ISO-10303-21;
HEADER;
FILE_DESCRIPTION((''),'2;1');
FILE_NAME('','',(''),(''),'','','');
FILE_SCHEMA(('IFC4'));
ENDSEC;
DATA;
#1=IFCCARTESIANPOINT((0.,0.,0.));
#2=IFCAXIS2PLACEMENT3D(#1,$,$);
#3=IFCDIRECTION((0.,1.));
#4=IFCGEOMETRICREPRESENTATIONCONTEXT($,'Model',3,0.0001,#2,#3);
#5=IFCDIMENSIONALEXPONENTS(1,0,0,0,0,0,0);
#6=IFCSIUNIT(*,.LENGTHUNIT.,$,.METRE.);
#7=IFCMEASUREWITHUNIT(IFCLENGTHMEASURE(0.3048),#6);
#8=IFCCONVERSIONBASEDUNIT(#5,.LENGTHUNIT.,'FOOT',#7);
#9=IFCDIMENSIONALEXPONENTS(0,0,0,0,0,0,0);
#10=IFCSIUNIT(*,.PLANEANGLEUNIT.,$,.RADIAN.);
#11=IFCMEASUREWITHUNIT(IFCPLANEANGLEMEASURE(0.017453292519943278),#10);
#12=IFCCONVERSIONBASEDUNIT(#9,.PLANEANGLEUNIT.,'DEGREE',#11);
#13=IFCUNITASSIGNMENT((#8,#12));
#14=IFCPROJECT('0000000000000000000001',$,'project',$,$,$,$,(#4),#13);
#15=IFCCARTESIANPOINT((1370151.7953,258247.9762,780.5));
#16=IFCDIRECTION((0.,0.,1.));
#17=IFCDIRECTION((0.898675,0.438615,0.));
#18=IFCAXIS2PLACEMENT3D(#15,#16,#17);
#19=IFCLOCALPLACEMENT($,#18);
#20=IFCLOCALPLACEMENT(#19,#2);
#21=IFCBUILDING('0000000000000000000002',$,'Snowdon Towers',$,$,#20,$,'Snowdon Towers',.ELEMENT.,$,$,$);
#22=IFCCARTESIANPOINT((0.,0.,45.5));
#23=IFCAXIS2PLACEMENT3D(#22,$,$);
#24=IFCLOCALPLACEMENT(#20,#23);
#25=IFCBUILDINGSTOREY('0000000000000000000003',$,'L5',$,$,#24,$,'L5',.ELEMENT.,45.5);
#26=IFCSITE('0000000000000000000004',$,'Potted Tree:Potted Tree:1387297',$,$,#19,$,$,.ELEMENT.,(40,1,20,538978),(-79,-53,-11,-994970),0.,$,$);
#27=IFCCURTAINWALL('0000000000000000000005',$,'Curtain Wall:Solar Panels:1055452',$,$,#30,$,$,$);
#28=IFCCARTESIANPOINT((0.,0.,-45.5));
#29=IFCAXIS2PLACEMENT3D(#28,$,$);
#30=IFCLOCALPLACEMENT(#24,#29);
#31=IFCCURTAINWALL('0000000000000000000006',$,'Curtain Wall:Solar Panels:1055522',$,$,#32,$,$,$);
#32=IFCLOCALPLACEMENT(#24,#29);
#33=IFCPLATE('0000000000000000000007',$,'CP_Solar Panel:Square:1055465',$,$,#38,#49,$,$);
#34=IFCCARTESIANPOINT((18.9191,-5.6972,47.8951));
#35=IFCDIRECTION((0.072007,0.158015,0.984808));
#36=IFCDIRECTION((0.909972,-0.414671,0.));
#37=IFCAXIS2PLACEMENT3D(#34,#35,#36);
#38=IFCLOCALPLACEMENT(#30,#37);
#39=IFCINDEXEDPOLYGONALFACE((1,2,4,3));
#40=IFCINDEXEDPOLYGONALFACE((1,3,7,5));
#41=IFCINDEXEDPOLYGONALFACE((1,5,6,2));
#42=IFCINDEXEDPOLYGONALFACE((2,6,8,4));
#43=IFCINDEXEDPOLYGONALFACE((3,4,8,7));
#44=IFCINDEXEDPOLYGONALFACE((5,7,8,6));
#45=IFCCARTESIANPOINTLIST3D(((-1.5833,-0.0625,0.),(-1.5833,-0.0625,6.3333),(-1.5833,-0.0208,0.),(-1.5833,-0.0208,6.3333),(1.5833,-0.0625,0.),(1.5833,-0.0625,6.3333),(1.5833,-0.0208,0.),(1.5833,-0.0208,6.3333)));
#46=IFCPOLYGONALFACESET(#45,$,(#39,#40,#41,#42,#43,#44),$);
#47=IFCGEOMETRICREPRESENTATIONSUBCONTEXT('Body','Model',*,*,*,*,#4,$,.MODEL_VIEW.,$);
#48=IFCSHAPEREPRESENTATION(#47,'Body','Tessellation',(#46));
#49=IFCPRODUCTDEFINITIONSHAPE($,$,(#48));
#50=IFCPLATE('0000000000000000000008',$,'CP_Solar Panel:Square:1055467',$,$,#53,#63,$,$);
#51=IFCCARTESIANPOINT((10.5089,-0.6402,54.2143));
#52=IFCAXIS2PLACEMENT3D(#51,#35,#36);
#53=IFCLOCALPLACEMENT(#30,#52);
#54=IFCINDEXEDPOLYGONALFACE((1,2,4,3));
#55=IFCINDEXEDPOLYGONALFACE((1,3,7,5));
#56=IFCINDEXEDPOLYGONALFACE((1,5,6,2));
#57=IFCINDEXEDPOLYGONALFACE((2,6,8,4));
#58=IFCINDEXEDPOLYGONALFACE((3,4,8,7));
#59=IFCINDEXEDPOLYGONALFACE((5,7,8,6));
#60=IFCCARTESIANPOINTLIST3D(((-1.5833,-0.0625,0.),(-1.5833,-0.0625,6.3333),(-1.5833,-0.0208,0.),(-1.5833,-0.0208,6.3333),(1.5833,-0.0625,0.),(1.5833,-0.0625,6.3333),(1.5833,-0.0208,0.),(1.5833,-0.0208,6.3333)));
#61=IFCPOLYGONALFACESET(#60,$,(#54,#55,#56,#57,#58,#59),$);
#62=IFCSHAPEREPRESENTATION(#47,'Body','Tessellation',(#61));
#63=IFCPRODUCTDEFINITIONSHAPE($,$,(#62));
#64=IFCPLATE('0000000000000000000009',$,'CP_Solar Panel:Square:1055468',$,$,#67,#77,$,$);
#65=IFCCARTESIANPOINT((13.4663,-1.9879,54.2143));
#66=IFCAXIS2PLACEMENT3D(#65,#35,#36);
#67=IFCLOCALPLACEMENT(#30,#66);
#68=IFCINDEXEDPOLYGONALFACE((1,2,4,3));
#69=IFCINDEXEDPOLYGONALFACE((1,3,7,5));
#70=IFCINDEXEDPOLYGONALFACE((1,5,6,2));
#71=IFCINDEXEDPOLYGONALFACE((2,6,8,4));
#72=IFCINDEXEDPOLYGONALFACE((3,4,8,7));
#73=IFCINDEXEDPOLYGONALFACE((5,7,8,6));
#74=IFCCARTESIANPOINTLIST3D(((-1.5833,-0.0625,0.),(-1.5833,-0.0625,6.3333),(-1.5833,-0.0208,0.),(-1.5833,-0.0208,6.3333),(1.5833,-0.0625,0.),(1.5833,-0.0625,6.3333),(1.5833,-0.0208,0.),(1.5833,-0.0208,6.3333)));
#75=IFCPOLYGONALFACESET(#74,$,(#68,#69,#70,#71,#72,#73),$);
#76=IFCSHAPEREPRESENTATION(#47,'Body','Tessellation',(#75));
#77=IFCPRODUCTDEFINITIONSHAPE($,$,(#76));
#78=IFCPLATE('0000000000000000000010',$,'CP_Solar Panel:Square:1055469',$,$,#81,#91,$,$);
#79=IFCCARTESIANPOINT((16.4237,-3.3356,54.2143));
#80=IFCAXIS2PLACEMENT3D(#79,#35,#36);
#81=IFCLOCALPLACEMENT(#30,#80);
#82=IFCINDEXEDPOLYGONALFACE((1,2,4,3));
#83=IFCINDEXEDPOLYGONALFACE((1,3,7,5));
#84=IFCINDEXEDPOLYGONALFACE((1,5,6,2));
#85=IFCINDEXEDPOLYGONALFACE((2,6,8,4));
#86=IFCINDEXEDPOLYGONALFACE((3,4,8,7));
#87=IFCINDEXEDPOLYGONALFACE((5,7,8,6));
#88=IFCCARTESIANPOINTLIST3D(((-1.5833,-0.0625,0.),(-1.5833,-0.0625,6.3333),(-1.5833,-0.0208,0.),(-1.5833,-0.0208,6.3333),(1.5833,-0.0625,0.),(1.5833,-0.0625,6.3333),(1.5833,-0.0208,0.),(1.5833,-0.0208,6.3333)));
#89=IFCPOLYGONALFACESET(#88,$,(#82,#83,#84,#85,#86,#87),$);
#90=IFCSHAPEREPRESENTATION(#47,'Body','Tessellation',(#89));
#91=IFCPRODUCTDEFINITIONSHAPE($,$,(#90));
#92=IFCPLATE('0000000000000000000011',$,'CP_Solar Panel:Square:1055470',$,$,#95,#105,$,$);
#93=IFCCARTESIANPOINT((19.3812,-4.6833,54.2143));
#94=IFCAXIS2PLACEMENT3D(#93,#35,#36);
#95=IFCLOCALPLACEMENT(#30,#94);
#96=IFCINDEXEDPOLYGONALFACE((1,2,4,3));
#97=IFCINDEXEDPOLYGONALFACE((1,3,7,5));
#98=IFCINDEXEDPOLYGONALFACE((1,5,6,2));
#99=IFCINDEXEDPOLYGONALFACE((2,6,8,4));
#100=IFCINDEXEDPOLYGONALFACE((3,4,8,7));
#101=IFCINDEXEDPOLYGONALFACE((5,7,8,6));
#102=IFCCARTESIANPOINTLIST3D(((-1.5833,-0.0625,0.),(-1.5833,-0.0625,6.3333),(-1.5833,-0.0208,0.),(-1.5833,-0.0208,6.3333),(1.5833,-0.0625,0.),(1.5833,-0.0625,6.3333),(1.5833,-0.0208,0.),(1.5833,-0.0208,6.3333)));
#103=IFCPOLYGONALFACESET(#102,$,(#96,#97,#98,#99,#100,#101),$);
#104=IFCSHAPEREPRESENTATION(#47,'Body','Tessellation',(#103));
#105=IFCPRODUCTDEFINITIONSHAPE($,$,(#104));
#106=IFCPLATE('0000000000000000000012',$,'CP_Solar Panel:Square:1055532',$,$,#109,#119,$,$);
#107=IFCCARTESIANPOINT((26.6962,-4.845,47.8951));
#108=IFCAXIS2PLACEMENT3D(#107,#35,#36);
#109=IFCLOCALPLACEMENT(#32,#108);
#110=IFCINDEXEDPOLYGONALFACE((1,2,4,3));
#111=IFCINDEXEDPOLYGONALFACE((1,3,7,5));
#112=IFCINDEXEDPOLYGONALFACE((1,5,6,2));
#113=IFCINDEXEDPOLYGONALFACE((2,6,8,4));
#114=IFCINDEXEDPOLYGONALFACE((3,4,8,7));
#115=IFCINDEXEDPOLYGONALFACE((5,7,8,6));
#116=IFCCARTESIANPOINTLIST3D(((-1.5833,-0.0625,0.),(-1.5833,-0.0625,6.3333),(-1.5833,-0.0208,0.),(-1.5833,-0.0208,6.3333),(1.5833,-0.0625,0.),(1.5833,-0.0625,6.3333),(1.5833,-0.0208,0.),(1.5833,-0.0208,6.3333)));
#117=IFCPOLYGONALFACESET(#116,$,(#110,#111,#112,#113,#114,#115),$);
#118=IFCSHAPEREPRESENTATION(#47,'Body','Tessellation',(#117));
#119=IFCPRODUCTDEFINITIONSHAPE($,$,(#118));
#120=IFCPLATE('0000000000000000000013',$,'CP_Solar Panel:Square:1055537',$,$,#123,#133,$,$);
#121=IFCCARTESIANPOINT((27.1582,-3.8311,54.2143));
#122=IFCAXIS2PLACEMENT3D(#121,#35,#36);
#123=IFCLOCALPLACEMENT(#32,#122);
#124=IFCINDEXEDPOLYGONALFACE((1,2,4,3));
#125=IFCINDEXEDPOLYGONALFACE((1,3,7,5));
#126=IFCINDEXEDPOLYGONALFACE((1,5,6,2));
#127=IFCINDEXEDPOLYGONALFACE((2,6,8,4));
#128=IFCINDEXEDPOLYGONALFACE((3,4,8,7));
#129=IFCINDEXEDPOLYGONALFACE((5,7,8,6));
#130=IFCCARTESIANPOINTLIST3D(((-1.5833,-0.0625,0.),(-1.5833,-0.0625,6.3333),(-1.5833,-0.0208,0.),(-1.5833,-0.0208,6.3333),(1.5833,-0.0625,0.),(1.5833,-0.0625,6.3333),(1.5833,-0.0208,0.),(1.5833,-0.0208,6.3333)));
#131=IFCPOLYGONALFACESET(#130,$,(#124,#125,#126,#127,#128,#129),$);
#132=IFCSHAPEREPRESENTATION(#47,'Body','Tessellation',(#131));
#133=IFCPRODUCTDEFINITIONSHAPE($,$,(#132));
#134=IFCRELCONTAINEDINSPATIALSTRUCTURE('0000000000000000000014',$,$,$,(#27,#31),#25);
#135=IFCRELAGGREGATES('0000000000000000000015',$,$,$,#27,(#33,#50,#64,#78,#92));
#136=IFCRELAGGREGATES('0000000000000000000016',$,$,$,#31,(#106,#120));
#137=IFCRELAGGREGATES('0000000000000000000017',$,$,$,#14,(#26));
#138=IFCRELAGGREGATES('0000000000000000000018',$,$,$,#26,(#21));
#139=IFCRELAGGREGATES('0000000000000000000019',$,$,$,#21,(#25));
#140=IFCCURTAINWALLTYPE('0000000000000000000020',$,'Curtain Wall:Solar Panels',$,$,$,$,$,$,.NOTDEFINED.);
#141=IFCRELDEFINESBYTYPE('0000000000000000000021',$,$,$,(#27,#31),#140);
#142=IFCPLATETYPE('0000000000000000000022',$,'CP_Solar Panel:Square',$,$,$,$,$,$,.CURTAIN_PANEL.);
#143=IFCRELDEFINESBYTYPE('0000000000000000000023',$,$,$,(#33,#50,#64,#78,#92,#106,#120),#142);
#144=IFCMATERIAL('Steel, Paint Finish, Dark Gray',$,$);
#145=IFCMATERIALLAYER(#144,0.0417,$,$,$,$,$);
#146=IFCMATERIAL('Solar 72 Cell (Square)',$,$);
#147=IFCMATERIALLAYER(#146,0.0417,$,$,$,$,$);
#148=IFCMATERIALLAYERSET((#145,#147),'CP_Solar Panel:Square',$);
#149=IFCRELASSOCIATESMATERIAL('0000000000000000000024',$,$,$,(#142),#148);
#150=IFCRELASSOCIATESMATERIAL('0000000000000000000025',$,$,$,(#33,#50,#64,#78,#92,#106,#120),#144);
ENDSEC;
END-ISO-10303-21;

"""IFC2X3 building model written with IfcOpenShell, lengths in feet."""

from ifc_helpers import new_model, entity, si_unit, converted_unit, direction, frame, origin, origin_2d_with_axis, place, context, subcontext, project, spatial, rectangle, extrude, source, transform, mapped, material, layer, layer_set, type_object, type_shapes, element, aggregate, save


model = new_model("IFC2X3")

# Units and contexts
model_context = context("Model", 3, precision=0.0001, world=origin(), true_north=direction((0.0, 1.0)))
body_context = subcontext(model_context, "Body", "Model", "MODEL_VIEW")
ifc_project = project(units=[converted_unit("LENGTHUNIT", "FOOT", entity("IfcLengthMeasure", 0.3048), si_unit("LENGTHUNIT", "METRE"), dimensions=[1, 0, 0, 0, 0, 0, 0]), converted_unit("PLANEANGLEUNIT", "DEGREE", entity("IfcPlaneAngleMeasure", 0.017453292519943278), si_unit("PLANEANGLEUNIT", "RADIAN"), dimensions=[0, 0, 0, 0, 0, 0, 0])], contexts=[model_context])

# Site, building, storey
site_placement = place(None, frame((1370151.7953, 258247.9762, 780.5), z_axis=(0.0, 0.0, 1.0), x_axis=(0.898675, 0.438615, 0.0)))
site = spatial("IfcSite", under=ifc_project, at=site_placement, Name="Potted Tree:Potted Tree:1387297", CompositionType="ELEMENT", RefLatitude=(40, 1, 20, 538978), RefLongitude=(-79, -53, -11, -994970), RefElevation=0.0)
building_placement = place(site_placement, origin())
building = spatial("IfcBuilding", under=site, at=building_placement, Name="Snowdon Towers", LongName="Snowdon Towers", CompositionType="ELEMENT")
storey_placement = place(building_placement, frame((0.0, 0.0, 45.5)))
storey = spatial("IfcBuildingStorey", under=building, at=storey_placement, Name="L5", LongName="L5", CompositionType="ELEMENT", Elevation=45.5)

# Curtain wall
curtain_wall_type = type_object("IfcCurtainWallType", Name="Curtain Wall:Solar Panels", PredefinedType="NOTDEFINED")
curtain_wall_1_placement = place(storey_placement, frame((0.0, 0.0, -45.5)))
curtain_wall_1 = element("IfcCurtainWall", 1, at=curtain_wall_1_placement, inside=storey, type_object=curtain_wall_type, Name="Curtain Wall:Solar Panels:1055452")

# Curtain wall
curtain_wall_2_placement = place(storey_placement, frame((0.0, 0.0, -45.5)))
curtain_wall_2 = element("IfcCurtainWall", 2, at=curtain_wall_2_placement, inside=storey, type_object=curtain_wall_type, Name="Curtain Wall:Solar Panels:1055522")

# Shared definitions
ifc_material_1 = material(Name="Steel, Paint Finish, Dark Gray")

# Plates
ifc_layer_1 = layer(ifc_material_1, 0.0417)
ifc_material_2 = material(Name="Solar 72 Cell (Square)")
ifc_layer_2 = layer(ifc_material_2, 0.0417)
ifc_layer_set = layer_set([ifc_layer_1, ifc_layer_2], Name="CP_Solar Panel:Square")
plate_type_1 = type_object("IfcPlateType", Name="CP_Solar Panel:Square", PredefinedType="CURTAIN_PANEL", material=ifc_layer_set)
shared_shape_1 = source(origin(), body_context, "Body", "SweptSolid", [
    extrude(rectangle(XDim=3.1667, YDim=0.0417, at=origin_2d_with_axis()), frame((0.0, -0.0417, 0.0)), (0.0, 0.0, 1.0), 6.3333),
])
type_shapes(plate_type_1, [shared_shape_1])
plate_1_placement = place(curtain_wall_1_placement, frame((18.9191, -5.6972, 47.8951), z_axis=(0.072007, 0.158015, 0.984808), x_axis=(0.909972, -0.414671, 0.0)))
plate_1 = element("IfcPlate", 3, at=plate_1_placement, type_object=plate_type_1, material=ifc_material_1, Name="CP_Solar Panel:Square:1055465", context=body_context, shape_type="MappedRepresentation", body=[
    mapped(shared_shape_1, transform((0.0, 0.0, 0.0), scale=1.0)),
])
plate_2_placement = place(curtain_wall_1_placement, frame((10.5089, -0.6402, 54.2143), z_axis=(0.072007, 0.158015, 0.984808), x_axis=(0.909972, -0.414671, 0.0)))
plate_2 = element("IfcPlate", 4, at=plate_2_placement, type_object=plate_type_1, material=ifc_material_1, Name="CP_Solar Panel:Square:1055467", context=body_context, shape_type="MappedRepresentation", body=[
    mapped(shared_shape_1, transform((0.0, 0.0, 0.0), scale=1.0)),
])
plate_3_placement = place(curtain_wall_1_placement, frame((13.4663, -1.9879, 54.2143), z_axis=(0.072007, 0.158015, 0.984808), x_axis=(0.909972, -0.414671, 0.0)))
plate_3 = element("IfcPlate", 5, at=plate_3_placement, type_object=plate_type_1, material=ifc_material_1, Name="CP_Solar Panel:Square:1055468", context=body_context, shape_type="MappedRepresentation", body=[
    mapped(shared_shape_1, transform((0.0, 0.0, 0.0), scale=1.0)),
])
plate_4_placement = place(curtain_wall_1_placement, frame((16.4237, -3.3356, 54.2143), z_axis=(0.072007, 0.158015, 0.984808), x_axis=(0.909972, -0.414671, 0.0)))
plate_4 = element("IfcPlate", 6, at=plate_4_placement, type_object=plate_type_1, material=ifc_material_1, Name="CP_Solar Panel:Square:1055469", context=body_context, shape_type="MappedRepresentation", body=[
    mapped(shared_shape_1, transform((0.0, 0.0, 0.0), scale=1.0)),
])
plate_5_placement = place(curtain_wall_1_placement, frame((19.3812, -4.6833, 54.2143), z_axis=(0.072007, 0.158015, 0.984808), x_axis=(0.909972, -0.414671, 0.0)))
plate_5 = element("IfcPlate", 7, at=plate_5_placement, type_object=plate_type_1, material=ifc_material_1, Name="CP_Solar Panel:Square:1055470", context=body_context, shape_type="MappedRepresentation", body=[
    mapped(shared_shape_1, transform((0.0, 0.0, 0.0), scale=1.0)),
])
aggregate(curtain_wall_1, [plate_1, plate_2, plate_3, plate_4, plate_5])
plate_6_placement = place(curtain_wall_2_placement, frame((26.6962, -4.845, 47.8951), z_axis=(0.072007, 0.158015, 0.984808), x_axis=(0.909972, -0.414671, 0.0)))
plate_6 = element("IfcPlate", 8, at=plate_6_placement, type_object=plate_type_1, material=ifc_material_1, Name="CP_Solar Panel:Square:1055532", context=body_context, shape_type="MappedRepresentation", body=[
    mapped(shared_shape_1, transform((0.0, 0.0, 0.0), scale=1.0)),
])
plate_7_placement = place(curtain_wall_2_placement, frame((27.1582, -3.8311, 54.2143), z_axis=(0.072007, 0.158015, 0.984808), x_axis=(0.909972, -0.414671, 0.0)))
plate_7 = element("IfcPlate", 9, at=plate_7_placement, type_object=plate_type_1, material=ifc_material_1, Name="CP_Solar Panel:Square:1055537", context=body_context, shape_type="MappedRepresentation", body=[
    mapped(shared_shape_1, transform((0.0, 0.0, 0.0), scale=1.0)),
])
aggregate(curtain_wall_2, [plate_6, plate_7])

save(model, "model.ifc")
